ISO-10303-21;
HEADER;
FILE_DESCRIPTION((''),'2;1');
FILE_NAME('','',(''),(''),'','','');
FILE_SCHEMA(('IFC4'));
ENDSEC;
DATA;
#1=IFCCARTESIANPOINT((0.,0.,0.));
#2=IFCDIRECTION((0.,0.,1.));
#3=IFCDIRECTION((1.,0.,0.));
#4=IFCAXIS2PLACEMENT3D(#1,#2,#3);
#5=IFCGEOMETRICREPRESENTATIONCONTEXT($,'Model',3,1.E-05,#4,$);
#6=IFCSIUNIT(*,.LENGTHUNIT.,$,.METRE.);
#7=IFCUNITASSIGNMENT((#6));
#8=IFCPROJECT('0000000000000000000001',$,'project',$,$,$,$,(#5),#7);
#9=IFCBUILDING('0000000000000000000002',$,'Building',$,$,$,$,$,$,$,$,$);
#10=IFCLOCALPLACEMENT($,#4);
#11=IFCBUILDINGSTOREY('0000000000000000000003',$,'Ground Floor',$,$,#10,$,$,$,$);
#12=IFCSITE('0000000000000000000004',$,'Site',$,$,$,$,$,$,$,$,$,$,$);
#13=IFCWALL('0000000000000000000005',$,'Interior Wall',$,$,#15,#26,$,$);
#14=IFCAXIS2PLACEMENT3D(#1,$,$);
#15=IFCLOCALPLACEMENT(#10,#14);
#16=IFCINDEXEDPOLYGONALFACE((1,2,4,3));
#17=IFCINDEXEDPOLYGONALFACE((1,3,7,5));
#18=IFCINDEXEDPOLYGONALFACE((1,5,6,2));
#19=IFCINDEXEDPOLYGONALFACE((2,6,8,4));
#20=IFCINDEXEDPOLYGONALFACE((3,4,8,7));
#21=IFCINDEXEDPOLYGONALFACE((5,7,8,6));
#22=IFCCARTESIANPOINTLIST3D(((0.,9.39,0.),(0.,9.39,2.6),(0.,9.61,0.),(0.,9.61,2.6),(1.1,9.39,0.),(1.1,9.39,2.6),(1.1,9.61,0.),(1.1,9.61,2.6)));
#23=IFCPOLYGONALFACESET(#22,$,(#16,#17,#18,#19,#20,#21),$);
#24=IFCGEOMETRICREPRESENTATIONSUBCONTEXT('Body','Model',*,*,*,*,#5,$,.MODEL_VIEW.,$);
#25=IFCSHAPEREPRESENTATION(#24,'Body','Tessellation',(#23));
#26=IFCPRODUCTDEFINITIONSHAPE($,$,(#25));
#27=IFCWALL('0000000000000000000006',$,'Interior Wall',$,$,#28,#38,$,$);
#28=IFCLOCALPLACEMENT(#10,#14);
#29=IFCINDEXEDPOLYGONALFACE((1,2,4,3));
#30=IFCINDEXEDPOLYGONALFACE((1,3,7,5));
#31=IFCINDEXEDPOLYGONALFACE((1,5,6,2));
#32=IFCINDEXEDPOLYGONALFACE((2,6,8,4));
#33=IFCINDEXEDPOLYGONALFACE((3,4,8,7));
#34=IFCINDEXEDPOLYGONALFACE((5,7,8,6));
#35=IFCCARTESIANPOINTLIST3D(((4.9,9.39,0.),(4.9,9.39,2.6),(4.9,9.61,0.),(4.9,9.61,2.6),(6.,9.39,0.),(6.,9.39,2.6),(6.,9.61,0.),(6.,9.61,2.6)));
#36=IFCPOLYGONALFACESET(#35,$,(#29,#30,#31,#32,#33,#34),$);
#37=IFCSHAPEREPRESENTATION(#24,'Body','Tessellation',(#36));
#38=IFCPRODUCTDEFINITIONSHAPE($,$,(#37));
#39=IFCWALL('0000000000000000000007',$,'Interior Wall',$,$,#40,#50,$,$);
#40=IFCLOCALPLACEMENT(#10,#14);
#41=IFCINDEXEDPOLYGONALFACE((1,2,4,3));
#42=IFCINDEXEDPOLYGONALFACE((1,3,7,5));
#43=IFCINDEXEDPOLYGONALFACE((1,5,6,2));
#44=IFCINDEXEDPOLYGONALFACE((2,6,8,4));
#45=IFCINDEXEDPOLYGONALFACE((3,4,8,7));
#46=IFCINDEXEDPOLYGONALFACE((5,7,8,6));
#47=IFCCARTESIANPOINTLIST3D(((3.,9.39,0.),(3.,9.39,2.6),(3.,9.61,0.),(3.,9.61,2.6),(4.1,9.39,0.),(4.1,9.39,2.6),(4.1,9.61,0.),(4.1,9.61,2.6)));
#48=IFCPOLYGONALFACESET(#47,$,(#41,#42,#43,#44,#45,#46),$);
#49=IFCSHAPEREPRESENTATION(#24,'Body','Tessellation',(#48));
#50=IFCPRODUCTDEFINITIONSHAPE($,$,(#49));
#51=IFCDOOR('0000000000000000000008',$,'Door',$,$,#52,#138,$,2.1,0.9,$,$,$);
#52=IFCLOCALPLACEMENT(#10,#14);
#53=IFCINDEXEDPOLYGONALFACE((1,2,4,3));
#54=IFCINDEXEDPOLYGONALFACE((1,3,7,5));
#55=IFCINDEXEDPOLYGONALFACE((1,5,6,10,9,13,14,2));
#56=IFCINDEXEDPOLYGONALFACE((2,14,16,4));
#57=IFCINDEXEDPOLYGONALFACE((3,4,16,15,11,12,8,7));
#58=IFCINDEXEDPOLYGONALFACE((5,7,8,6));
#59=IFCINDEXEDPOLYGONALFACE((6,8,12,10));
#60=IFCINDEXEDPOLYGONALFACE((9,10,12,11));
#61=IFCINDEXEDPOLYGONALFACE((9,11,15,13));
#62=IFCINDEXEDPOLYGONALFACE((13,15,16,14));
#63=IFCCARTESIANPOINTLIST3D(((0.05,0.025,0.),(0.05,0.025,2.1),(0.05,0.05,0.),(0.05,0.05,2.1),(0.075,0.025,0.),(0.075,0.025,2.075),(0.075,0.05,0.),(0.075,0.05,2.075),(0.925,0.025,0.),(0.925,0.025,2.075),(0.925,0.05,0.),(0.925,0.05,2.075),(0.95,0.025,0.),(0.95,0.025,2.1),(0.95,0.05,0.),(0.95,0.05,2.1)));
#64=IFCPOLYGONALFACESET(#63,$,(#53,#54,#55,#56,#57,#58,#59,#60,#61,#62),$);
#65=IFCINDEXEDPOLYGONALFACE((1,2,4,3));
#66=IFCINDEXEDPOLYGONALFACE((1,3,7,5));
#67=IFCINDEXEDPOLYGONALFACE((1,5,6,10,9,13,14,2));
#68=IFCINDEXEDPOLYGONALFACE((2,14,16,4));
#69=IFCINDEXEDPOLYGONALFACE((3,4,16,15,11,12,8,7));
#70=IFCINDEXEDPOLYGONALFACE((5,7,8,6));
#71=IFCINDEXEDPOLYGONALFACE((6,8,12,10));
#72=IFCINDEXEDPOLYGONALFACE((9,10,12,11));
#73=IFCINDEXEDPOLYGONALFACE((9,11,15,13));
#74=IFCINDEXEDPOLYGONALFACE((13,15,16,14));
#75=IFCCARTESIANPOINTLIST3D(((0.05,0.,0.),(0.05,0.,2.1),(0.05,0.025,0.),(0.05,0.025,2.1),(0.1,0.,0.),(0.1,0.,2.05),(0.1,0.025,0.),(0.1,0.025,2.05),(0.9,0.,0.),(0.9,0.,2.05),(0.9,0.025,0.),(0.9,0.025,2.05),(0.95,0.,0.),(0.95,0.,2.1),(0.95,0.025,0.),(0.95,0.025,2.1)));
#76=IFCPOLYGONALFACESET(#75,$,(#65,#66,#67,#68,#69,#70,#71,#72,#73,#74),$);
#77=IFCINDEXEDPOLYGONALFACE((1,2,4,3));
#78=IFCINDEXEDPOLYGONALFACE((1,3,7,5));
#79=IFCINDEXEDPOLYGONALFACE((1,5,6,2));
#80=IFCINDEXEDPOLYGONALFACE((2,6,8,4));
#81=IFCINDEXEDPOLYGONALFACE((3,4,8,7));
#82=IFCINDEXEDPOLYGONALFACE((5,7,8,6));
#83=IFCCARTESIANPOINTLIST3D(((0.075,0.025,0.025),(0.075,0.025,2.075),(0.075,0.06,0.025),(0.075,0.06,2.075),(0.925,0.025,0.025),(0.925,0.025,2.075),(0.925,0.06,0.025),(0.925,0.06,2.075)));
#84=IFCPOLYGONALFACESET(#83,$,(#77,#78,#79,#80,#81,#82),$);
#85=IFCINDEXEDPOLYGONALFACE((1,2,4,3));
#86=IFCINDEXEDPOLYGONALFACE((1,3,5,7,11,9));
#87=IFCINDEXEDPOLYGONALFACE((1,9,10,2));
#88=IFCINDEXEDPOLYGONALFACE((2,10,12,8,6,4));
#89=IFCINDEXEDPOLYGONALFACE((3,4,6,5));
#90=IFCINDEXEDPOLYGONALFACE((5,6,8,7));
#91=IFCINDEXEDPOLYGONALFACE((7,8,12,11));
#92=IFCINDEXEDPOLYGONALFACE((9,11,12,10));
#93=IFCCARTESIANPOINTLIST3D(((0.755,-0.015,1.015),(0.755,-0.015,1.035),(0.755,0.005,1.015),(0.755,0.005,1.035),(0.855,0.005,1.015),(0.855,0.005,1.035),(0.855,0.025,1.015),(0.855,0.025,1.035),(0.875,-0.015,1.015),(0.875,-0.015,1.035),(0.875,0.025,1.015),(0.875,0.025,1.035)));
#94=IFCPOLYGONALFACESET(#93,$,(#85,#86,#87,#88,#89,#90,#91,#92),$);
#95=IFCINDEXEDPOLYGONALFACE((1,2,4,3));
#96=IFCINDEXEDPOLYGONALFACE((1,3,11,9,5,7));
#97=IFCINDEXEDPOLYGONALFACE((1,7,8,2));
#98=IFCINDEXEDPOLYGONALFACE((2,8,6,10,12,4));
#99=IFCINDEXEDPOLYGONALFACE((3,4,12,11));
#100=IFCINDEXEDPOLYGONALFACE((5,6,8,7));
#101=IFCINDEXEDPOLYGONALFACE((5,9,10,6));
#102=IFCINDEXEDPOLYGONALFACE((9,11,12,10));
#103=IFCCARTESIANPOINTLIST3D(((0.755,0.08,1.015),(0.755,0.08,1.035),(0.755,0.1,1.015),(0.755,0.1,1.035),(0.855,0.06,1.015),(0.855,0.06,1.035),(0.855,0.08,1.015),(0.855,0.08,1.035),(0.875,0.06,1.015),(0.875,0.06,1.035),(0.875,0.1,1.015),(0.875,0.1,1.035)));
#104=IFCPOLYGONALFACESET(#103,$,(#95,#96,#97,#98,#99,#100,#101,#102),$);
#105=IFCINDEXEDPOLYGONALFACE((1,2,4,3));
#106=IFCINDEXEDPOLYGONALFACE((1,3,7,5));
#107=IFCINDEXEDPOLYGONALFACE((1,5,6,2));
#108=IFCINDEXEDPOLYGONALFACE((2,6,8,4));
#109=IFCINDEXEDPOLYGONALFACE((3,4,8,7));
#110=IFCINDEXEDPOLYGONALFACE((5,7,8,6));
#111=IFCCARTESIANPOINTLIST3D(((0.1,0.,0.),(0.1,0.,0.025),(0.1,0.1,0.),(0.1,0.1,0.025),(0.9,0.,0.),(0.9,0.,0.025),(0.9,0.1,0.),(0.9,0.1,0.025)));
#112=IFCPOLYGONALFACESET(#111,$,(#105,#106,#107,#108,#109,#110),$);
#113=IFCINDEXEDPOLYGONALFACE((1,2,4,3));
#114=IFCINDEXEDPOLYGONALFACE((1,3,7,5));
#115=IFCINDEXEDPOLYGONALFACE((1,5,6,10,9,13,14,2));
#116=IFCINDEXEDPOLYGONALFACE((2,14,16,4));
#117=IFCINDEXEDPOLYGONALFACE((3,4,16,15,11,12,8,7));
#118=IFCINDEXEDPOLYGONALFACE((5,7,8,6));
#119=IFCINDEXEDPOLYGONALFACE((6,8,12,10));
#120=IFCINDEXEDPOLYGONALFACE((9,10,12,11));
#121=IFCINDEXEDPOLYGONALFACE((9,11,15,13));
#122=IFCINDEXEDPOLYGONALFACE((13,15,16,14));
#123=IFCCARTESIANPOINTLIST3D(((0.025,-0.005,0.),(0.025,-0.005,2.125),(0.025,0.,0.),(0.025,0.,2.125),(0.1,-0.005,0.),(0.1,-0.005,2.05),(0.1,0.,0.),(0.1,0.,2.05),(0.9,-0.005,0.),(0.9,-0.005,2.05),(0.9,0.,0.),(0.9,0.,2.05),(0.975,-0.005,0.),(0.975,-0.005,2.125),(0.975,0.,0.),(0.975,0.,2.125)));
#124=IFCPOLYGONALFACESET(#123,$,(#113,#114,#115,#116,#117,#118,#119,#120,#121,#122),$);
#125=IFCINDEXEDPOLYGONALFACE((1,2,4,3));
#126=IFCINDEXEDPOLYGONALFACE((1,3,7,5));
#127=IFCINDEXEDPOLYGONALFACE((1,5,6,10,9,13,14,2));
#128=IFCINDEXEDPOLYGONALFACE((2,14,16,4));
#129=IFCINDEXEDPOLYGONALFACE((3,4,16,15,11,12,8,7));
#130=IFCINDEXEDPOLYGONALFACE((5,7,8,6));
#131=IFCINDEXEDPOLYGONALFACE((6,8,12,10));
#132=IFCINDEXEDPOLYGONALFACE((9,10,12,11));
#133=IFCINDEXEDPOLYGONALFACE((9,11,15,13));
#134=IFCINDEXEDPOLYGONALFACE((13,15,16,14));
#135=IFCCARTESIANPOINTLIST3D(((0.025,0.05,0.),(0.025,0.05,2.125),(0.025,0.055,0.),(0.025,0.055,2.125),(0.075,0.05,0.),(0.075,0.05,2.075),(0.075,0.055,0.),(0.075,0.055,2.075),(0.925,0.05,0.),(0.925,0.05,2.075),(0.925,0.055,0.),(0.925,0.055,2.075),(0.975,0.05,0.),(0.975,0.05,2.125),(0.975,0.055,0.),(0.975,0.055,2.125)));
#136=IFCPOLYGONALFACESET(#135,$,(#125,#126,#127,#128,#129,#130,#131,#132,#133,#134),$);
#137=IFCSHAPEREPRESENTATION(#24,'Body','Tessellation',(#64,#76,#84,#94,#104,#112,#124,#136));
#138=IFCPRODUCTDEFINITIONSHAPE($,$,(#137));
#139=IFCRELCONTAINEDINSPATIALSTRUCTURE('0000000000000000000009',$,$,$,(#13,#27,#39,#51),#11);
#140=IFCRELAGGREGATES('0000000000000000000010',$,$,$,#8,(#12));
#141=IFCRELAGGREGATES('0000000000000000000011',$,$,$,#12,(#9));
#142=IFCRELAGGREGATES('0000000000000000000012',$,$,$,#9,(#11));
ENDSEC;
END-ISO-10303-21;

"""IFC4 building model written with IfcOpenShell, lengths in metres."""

from ifc_helpers import new_model, si_unit, frame, origin_with_axes, place, context, subcontext, project, spatial, line, indexed_curve, outline, extrude, element, save


model = new_model("IFC4")

# Units and contexts
model_context = context("Model", 3, precision=1e-05, world=origin_with_axes())
body_context = subcontext(model_context, "Body", "Model", "MODEL_VIEW")
ifc_project = project(units=[si_unit("LENGTHUNIT", "METRE")], contexts=[model_context])

# Site, building, storey
site = spatial("IfcSite", under=ifc_project, Name="Site")
building = spatial("IfcBuilding", under=site, Name="Building")
storey_placement = place(None, origin_with_axes())
storey = spatial("IfcBuildingStorey", under=building, at=storey_placement, Name="Ground Floor")

# Walls
for number, where, z_axis, x_axis, name in (
    (1, (1.1, 9.5, 0.0), (0.0, 0.0, 1.0), (-1.0, 0.0, 0.0), "Interior Wall"),
):
    element("IfcWall", number, at=place(storey_placement, frame(where, z_axis=z_axis, x_axis=x_axis)), inside=storey, Name=name, context=body_context, shape_type="SweptSolid", body=[
        extrude(outline(indexed_curve([(0.0, 0.0), (0.0, 0.22), (1.1, 0.22), (1.1, 0.0), (0.0, 0.0)], self_intersect=False)), frame((0.0, -0.11, 0.0), z_axis=(0.0, 0.0, 1.0), x_axis=(1.0, 0.0, 0.0)), (0.0, 0.0, 1.0), 2.6),
    ])
for number, where, z_axis, x_axis, name in (
    (2, (6.0, 9.5, 0.0), (0.0, 0.0, 1.0), (-1.0, 0.0, 0.0), "Interior Wall"),
    (3, (4.1, 9.5, 0.0), (0.0, 0.0, 1.0), (-1.0, 0.0, 0.0), "Interior Wall"),
):
    element("IfcWall", number, at=place(storey_placement, frame(where, z_axis=z_axis, x_axis=x_axis)), inside=storey, Name=name, context=body_context, shape_type="SweptSolid", body=[
        extrude(outline(indexed_curve([(0.0, 0.0), (0.0, 0.22), (1.1, 0.22), (1.1, 0.0), (0.0, 0.0)], self_intersect=False)), frame((0.0, -0.11, 0.0), z_axis=(0.0, 0.0, 1.0), x_axis=(1.0, 0.0, 0.0)), (0.0, 0.0, 1.0), 2.6),
    ])

# Door
door_1_placement = place(storey_placement, frame((0.05, 0.0, 0.0), z_axis=(0.0, 0.0, 1.0), x_axis=(1.0, 0.0, 0.0)))
element("IfcDoor", 4, at=door_1_placement, inside=storey, Name="Door", OverallHeight=2.1, OverallWidth=0.9, context=body_context, shape_type="SweptSolid", body=[
    extrude(outline(indexed_curve([(0.0, 0.0), (0.0, 2.1), (0.9, 2.1), (0.9, 0.0), (0.875, 0.0), (0.875, 2.075), (0.025, 2.075), (0.025, 0.0)], segments=[line(1, 2, 3, 4, 5, 6, 7, 8, 1)])), frame((0.0, 0.025, 0.0), z_axis=(0.0, -1.0, 0.0), x_axis=(1.0, 0.0, 0.0)), (0.0, 0.0, -1.0), 0.025),
    extrude(outline(indexed_curve([(0.0, 0.0), (0.0, 2.1), (0.9, 2.1), (0.9, 0.0), (0.85, 0.0), (0.85, 2.05), (0.05, 2.05), (0.05, 0.0)], segments=[line(1, 2, 3, 4, 5, 6, 7, 8, 1)])), frame((0.0, 0.0, 0.0), z_axis=(0.0, -1.0, 0.0), x_axis=(1.0, 0.0, 0.0)), (0.0, 0.0, -1.0), 0.025),
    extrude(outline(indexed_curve([(0.0, 0.0), (0.85, 0.0), (0.85, 0.035), (0.0, 0.035)], segments=[line(1, 2, 3, 4, 1)])), frame((0.025, 0.025, 0.025), z_axis=(0.0, 0.0, 1.0), x_axis=(1.0, 0.0, 0.0)), (0.0, 0.0, 1.0), 2.05),
    extrude(outline(indexed_curve([(0.0, 0.0), (0.0, -0.04), (-0.12, -0.04), (-0.12, -0.02), (-0.02, -0.02), (-0.02, 0.0)], segments=[line(1, 2, 3, 4, 5, 6, 1)])), frame((0.825, 0.025, 1.015), z_axis=(0.0, 0.0, 1.0), x_axis=(1.0, 0.0, 0.0)), (0.0, 0.0, 1.0), 0.02),
    extrude(outline(indexed_curve([(0.0, 0.0), (0.0, 0.04), (-0.12, 0.04), (-0.12, 0.02), (-0.02, 0.02), (-0.02, 0.0)], segments=[line(1, 2, 3, 4, 5, 6, 1)])), frame((0.825, 0.06, 1.015), z_axis=(0.0, 0.0, 1.0), x_axis=(1.0, 0.0, 0.0)), (0.0, 0.0, 1.0), 0.02),
    extrude(outline(indexed_curve([(0.0, 0.0), (0.8, 0.0), (0.8, 0.1), (0.0, 0.1)], segments=[line(1, 2, 3, 4, 1)])), frame((0.05, 0.0, 0.0), z_axis=(0.0, 0.0, 1.0), x_axis=(1.0, 0.0, 0.0)), (0.0, 0.0, 1.0), 0.025),
    extrude(outline(indexed_curve([(0.0, 0.0), (0.0, 2.125), (0.95, 2.125), (0.95, 0.0), (0.875, 0.0), (0.875, 2.05), (0.075, 2.05), (0.075, 0.0)], segments=[line(1, 2, 3, 4, 5, 6, 7, 8, 1)])), frame((-0.025, -0.005, 0.0), z_axis=(0.0, -1.0, 0.0), x_axis=(1.0, 0.0, 0.0)), (0.0, 0.0, -1.0), 0.005),
    extrude(outline(indexed_curve([(0.0, 0.0), (0.0, 2.125), (0.95, 2.125), (0.95, 0.0), (0.9, 0.0), (0.9, 2.075), (0.05, 2.075), (0.05, 0.0)], segments=[line(1, 2, 3, 4, 5, 6, 7, 8, 1)])), frame((-0.025, 0.05, 0.0), z_axis=(0.0, -1.0, 0.0), x_axis=(1.0, 0.0, 0.0)), (0.0, 0.0, -1.0), 0.005),
])

save(model, "model.ifc")
